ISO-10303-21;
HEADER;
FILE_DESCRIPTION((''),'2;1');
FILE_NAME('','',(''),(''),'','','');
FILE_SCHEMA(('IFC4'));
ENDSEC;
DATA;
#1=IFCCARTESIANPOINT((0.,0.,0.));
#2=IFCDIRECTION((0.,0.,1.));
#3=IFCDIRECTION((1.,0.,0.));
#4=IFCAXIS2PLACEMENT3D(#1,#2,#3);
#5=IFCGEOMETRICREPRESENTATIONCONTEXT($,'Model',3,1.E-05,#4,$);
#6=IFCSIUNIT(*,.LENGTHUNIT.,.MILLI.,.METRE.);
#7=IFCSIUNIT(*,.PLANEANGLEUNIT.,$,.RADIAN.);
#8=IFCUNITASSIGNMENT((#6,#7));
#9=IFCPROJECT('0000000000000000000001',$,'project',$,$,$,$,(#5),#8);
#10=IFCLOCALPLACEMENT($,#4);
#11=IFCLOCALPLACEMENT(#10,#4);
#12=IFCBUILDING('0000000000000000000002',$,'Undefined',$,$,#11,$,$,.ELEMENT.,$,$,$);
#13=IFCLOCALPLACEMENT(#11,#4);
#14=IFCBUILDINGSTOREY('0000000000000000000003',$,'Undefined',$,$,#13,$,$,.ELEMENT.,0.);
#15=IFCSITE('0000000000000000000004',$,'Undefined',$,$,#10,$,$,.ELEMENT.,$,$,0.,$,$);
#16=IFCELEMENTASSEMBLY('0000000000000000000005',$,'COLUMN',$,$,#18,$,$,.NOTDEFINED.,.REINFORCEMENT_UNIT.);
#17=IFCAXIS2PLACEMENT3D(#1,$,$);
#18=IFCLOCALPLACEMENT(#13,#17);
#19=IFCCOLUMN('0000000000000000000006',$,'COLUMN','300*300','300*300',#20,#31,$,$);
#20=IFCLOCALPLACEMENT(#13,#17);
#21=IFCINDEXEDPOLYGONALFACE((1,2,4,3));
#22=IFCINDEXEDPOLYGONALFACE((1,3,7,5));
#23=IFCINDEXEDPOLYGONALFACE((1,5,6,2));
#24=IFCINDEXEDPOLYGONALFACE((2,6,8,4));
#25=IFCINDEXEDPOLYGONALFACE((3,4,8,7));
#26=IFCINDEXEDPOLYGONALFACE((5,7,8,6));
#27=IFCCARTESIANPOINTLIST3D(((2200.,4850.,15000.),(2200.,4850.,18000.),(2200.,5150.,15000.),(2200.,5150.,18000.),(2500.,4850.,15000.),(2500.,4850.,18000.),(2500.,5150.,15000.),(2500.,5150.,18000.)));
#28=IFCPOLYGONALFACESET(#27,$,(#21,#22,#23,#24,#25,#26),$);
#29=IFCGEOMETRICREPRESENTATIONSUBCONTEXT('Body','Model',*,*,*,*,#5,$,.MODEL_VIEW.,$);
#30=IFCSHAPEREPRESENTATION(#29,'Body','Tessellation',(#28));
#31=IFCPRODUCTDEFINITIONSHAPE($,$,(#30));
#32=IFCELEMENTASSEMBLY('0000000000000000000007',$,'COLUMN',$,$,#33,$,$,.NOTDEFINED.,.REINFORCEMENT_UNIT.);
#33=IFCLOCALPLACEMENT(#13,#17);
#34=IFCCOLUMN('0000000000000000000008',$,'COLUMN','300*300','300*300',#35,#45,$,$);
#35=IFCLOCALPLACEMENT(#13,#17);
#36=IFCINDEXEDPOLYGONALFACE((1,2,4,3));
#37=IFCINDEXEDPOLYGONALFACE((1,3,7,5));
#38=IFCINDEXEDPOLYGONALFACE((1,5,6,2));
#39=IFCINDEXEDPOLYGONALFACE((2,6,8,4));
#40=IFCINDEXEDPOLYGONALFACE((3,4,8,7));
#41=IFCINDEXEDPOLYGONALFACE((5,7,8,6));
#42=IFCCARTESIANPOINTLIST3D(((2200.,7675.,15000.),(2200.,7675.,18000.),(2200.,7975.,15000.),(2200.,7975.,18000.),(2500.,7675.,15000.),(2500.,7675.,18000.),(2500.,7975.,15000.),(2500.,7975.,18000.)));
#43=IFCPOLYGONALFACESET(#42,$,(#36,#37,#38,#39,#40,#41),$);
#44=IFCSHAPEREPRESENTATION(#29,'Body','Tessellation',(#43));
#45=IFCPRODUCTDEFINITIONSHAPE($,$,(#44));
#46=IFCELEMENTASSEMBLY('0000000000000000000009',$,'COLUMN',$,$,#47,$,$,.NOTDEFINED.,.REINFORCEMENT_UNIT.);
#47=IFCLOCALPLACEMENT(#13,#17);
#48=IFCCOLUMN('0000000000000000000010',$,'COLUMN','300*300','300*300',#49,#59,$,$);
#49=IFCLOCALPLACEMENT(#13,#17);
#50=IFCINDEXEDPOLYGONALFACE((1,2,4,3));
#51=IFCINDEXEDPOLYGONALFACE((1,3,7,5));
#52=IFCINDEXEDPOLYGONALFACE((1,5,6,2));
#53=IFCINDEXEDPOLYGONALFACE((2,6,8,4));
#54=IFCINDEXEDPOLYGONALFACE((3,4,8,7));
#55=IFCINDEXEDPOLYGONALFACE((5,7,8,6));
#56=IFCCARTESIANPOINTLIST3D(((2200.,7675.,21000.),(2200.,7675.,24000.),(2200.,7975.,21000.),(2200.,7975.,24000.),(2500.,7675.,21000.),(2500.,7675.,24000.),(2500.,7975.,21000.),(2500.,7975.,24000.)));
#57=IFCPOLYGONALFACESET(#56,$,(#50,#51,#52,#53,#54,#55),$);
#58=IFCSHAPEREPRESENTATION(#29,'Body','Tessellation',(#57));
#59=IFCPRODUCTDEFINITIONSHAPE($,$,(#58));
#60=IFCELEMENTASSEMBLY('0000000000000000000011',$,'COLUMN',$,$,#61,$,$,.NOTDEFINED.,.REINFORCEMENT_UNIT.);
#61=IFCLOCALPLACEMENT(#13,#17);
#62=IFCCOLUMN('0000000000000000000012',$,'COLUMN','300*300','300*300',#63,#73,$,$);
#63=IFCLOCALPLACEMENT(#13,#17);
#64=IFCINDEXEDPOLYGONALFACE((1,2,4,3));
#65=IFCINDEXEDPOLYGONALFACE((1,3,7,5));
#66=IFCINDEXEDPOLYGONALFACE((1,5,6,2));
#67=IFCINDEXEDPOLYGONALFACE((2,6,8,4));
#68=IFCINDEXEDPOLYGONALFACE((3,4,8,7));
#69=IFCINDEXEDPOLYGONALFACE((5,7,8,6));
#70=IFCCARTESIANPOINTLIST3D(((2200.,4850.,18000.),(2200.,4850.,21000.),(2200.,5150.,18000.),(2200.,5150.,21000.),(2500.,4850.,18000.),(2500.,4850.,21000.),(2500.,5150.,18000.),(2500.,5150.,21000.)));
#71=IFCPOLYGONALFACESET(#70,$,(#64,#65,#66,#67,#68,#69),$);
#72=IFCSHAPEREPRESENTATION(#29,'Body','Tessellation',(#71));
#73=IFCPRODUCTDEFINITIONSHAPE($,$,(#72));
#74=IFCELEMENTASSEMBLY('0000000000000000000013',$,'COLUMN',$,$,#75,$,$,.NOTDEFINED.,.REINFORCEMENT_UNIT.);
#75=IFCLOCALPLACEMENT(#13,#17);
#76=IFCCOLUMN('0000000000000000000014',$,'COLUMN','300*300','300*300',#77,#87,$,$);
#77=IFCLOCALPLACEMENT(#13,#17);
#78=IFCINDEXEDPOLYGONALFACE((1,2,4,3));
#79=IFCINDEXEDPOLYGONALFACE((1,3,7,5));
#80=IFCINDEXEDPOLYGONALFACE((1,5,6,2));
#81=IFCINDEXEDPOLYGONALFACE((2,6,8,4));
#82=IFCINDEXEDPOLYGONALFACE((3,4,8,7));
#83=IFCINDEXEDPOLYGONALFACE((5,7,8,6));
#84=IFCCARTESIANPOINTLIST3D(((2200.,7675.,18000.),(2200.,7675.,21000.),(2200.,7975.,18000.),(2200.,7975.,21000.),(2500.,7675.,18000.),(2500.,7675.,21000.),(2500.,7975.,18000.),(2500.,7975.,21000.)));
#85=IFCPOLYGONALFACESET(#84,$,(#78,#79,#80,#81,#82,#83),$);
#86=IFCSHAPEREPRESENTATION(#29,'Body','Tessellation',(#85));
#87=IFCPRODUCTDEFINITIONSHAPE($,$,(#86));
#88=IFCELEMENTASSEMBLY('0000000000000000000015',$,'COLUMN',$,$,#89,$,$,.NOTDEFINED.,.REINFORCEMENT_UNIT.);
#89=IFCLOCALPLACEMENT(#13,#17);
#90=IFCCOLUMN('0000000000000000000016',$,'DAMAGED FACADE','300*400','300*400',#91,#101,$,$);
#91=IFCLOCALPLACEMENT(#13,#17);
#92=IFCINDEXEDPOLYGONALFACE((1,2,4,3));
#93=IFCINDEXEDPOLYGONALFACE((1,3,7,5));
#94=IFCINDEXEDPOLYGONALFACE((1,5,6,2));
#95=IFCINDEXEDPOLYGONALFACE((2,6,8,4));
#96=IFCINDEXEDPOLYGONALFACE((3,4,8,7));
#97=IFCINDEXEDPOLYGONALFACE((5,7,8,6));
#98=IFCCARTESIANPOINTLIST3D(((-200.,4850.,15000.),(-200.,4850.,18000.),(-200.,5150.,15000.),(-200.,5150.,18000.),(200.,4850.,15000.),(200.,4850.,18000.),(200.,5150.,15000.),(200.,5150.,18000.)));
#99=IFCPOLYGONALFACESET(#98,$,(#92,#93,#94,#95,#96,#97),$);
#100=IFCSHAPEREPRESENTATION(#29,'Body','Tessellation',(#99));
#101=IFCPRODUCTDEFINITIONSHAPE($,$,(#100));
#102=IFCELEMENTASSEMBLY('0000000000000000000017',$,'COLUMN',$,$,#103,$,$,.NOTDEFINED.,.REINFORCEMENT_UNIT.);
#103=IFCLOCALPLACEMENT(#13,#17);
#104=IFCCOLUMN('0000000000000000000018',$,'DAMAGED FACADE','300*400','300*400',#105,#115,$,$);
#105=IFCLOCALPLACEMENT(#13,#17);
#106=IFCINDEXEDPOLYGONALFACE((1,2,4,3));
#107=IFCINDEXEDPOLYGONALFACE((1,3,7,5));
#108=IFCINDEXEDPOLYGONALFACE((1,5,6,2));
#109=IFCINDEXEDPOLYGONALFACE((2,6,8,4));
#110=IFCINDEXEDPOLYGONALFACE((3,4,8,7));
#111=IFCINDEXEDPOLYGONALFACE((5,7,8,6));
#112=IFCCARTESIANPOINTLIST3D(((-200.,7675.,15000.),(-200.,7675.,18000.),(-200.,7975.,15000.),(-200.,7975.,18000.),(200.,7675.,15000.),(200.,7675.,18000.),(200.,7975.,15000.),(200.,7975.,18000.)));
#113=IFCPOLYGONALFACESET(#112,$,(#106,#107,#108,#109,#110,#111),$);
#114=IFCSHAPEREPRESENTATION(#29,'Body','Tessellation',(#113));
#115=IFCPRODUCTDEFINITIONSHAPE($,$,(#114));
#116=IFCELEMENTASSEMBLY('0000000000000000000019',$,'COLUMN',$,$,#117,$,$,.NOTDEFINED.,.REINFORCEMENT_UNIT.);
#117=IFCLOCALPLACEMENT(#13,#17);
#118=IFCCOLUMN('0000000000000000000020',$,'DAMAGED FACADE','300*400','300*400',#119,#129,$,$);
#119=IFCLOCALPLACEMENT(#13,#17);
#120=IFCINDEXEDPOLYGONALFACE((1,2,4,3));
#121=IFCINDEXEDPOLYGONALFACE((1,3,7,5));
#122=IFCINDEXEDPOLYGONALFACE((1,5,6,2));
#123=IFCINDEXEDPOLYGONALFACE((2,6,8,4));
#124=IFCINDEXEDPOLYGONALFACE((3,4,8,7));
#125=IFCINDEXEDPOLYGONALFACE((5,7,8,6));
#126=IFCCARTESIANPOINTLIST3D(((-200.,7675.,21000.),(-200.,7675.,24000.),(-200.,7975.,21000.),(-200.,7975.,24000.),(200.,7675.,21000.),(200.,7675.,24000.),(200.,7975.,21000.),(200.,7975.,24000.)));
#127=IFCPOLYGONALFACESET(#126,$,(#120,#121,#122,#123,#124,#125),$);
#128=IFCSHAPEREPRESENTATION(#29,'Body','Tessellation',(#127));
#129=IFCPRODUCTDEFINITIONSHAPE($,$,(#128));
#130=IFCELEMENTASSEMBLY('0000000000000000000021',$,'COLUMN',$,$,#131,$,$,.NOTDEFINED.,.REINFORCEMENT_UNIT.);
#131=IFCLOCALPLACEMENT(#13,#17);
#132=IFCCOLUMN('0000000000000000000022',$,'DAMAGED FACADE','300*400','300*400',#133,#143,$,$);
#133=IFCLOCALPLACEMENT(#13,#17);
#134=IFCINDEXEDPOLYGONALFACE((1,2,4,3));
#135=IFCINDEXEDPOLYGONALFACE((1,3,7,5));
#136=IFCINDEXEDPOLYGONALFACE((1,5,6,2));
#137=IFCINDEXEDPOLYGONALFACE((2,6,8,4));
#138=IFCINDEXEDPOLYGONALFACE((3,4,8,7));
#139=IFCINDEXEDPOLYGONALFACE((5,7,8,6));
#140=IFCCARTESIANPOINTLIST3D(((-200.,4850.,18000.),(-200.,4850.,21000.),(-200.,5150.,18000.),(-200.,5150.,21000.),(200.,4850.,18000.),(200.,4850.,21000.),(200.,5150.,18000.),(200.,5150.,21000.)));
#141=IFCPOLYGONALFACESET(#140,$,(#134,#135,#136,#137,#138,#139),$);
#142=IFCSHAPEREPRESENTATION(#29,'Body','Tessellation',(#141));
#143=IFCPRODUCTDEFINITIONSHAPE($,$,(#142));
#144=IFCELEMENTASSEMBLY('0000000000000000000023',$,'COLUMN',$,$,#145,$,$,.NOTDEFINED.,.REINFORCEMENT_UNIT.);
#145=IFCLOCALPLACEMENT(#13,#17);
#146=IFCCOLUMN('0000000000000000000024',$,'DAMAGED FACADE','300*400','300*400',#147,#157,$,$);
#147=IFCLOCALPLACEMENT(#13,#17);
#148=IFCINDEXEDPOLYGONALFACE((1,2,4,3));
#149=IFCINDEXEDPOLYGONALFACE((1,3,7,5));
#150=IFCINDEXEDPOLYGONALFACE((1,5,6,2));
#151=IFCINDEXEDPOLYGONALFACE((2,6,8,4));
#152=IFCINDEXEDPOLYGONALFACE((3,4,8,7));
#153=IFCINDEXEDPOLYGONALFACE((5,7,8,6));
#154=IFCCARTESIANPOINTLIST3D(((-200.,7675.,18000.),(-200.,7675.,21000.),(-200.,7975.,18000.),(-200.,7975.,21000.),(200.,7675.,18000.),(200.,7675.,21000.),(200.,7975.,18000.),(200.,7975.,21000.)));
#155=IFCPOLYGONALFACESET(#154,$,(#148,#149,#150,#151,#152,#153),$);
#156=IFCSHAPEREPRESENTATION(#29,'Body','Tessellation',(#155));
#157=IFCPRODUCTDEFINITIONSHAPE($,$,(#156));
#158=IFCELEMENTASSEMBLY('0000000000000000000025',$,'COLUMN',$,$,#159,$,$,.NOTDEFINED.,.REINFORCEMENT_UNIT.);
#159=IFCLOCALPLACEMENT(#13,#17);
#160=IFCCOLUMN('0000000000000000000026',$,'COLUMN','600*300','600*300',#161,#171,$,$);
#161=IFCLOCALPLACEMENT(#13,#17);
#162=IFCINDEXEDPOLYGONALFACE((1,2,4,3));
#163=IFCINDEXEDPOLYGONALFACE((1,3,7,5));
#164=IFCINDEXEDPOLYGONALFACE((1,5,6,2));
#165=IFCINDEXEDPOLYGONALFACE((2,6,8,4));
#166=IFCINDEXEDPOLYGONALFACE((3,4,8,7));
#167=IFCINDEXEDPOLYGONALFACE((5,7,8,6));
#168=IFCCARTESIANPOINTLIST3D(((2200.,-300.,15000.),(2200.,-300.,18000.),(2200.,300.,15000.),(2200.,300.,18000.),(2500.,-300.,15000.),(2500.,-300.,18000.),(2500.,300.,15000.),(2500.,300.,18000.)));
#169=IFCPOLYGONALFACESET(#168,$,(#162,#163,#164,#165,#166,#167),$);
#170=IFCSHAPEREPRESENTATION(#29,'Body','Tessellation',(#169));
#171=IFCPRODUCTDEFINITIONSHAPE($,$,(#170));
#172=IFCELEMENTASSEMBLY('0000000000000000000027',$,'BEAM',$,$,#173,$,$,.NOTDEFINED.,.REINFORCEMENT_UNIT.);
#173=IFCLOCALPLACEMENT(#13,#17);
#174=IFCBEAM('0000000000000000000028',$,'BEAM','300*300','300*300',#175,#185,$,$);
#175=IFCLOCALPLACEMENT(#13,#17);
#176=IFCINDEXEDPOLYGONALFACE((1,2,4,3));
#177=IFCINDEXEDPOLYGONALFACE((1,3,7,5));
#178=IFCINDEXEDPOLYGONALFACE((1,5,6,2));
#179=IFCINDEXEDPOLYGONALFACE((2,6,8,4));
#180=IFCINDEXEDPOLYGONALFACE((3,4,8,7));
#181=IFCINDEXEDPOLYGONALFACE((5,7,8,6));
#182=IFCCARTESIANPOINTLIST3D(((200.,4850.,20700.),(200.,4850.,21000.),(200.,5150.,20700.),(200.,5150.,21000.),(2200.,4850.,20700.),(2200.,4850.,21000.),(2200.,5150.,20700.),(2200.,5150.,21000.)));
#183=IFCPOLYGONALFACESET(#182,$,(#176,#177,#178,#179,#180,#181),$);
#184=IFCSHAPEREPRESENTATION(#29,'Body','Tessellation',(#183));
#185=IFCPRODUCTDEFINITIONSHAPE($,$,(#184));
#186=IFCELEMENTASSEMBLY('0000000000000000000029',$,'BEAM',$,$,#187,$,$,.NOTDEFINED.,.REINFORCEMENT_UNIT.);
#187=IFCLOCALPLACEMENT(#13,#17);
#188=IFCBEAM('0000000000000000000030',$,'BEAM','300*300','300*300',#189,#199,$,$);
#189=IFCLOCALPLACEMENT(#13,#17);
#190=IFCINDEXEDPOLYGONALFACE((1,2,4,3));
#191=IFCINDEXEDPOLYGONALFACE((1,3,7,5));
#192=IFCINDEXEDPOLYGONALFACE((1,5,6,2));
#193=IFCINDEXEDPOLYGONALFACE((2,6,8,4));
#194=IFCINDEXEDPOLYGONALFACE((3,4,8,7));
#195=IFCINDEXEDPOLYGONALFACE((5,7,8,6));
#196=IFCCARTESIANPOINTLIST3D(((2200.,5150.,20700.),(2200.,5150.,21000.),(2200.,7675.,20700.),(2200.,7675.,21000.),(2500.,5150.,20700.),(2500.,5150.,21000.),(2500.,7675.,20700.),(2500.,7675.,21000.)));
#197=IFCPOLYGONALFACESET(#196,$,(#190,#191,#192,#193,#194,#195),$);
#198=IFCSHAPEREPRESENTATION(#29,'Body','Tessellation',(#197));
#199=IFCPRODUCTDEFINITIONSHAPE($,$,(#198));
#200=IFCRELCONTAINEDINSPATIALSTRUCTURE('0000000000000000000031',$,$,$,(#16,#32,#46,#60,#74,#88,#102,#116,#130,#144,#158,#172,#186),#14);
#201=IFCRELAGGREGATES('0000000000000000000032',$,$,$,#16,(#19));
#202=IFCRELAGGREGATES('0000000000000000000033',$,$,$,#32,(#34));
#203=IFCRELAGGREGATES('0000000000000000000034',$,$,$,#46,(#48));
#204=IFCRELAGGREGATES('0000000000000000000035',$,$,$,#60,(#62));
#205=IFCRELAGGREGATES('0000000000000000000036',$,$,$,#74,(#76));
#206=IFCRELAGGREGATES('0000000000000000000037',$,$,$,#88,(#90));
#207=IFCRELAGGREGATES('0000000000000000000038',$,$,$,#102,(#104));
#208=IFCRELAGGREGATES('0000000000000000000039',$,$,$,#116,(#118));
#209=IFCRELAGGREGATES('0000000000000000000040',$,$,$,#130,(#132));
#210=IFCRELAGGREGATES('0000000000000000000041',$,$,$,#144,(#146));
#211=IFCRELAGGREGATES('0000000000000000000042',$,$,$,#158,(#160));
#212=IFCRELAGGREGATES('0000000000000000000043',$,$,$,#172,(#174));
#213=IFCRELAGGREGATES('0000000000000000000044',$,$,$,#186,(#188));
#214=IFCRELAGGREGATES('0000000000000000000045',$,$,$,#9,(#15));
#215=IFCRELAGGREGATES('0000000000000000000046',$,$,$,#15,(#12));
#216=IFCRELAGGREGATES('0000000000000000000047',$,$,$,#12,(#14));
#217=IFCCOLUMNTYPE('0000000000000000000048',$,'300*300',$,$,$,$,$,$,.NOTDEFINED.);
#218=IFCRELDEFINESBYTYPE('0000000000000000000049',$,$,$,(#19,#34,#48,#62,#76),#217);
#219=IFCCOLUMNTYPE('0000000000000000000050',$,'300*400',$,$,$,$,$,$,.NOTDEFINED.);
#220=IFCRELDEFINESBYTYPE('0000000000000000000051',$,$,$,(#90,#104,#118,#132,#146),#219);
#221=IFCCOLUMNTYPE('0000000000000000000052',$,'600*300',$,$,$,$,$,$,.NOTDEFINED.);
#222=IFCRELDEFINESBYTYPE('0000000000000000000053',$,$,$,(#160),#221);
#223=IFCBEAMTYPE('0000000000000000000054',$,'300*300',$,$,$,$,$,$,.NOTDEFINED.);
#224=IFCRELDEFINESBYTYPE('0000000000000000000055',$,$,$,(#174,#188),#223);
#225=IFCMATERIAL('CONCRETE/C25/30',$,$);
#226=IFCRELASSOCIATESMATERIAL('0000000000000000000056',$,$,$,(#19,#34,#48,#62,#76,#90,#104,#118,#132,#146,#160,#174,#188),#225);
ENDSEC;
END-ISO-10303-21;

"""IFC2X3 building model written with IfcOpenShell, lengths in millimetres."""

from ifc_helpers import new_model, si_unit, frame, origin_with_axes, origin_2d_with_axis, place, context, subcontext, project, spatial, rectangle, extrude, material, type_object, element, aggregate, save


model = new_model("IFC2X3")

# Units and contexts
model_context = context("Model", 3, precision=1e-05, world=origin_with_axes())
body_context = subcontext(model_context, "Body", "Model", "MODEL_VIEW")
ifc_project = project(units=[si_unit("LENGTHUNIT", "METRE", prefix="MILLI"), si_unit("PLANEANGLEUNIT", "RADIAN")], contexts=[model_context])

# Site, building, storey
site_placement = place(None, origin_with_axes())
site = spatial("IfcSite", under=ifc_project, at=site_placement, Name="Undefined", CompositionType="ELEMENT", RefElevation=0.0)
building_placement = place(site_placement, origin_with_axes())
building = spatial("IfcBuilding", under=site, at=building_placement, Name="Undefined", CompositionType="ELEMENT")
storey_placement = place(building_placement, origin_with_axes())
storey = spatial("IfcBuildingStorey", under=building, at=storey_placement, Name="Undefined", CompositionType="ELEMENT", Elevation=0.0)

# Element assemblies, columns
assembly_1_placement = place(storey_placement, origin_with_axes())
assembly_1 = element("IfcElementAssembly", 1, at=assembly_1_placement, inside=storey, Name="COLUMN", AssemblyPlace="NOTDEFINED", PredefinedType="REINFORCEMENT_UNIT")
ifc_material_1 = material(Name="CONCRETE/C25/30")
column_type_1 = type_object("IfcColumnType", Name="300*300", PredefinedType="NOTDEFINED")
column_1_placement = place(assembly_1_placement, frame((2350.0, 5000.0, 15000.0), z_axis=(0.0, 0.0, 1.0), x_axis=(1.0, 0.0, 0.0)))
column_1 = element("IfcColumn", 2, at=column_1_placement, type_object=column_type_1, material=ifc_material_1, Name="COLUMN", Description="300*300", ObjectType="300*300", context=body_context, shape_type="SweptSolid", body=[
    extrude(rectangle(XDim=300.0, YDim=300.0, at=origin_2d_with_axis()), frame((0.0, 0.0, 3000.0), z_axis=(0.0, 0.0, -1.0), x_axis=(-1.0, 0.0, 0.0)), (0.0, 0.0, 1.0), 3000.0),
])
aggregate(assembly_1, [column_1])
assembly_2_placement = place(storey_placement, origin_with_axes())
assembly_2 = element("IfcElementAssembly", 3, at=assembly_2_placement, inside=storey, Name="COLUMN", AssemblyPlace="NOTDEFINED", PredefinedType="REINFORCEMENT_UNIT")
column_2_placement = place(assembly_2_placement, frame((2350.0, 7825.0, 15000.0), z_axis=(0.0, 0.0, 1.0), x_axis=(1.0, 0.0, 0.0)))
column_2 = element("IfcColumn", 4, at=column_2_placement, type_object=column_type_1, material=ifc_material_1, Name="COLUMN", Description="300*300", ObjectType="300*300", context=body_context, shape_type="SweptSolid", body=[
    extrude(rectangle(XDim=300.0, YDim=300.0, at=origin_2d_with_axis()), frame((0.0, 0.0, 3000.0), z_axis=(0.0, 0.0, -1.0), x_axis=(-1.0, 0.0, 0.0)), (0.0, 0.0, 1.0), 3000.0),
])
aggregate(assembly_2, [column_2])
assembly_3_placement = place(storey_placement, origin_with_axes())
assembly_3 = element("IfcElementAssembly", 5, at=assembly_3_placement, inside=storey, Name="COLUMN", AssemblyPlace="NOTDEFINED", PredefinedType="REINFORCEMENT_UNIT")
column_3_placement = place(assembly_3_placement, frame((2350.0, 7825.0, 21000.0), z_axis=(0.0, 0.0, 1.0), x_axis=(1.0, 0.0, 0.0)))
column_3 = element("IfcColumn", 6, at=column_3_placement, type_object=column_type_1, material=ifc_material_1, Name="COLUMN", Description="300*300", ObjectType="300*300", context=body_context, shape_type="SweptSolid", body=[
    extrude(rectangle(XDim=300.0, YDim=300.0, at=origin_2d_with_axis()), frame((0.0, 0.0, 3000.0), z_axis=(0.0, 0.0, -1.0), x_axis=(-1.0, 0.0, 0.0)), (0.0, 0.0, 1.0), 3000.0),
])
aggregate(assembly_3, [column_3])
assembly_4_placement = place(storey_placement, origin_with_axes())
assembly_4 = element("IfcElementAssembly", 7, at=assembly_4_placement, inside=storey, Name="COLUMN", AssemblyPlace="NOTDEFINED", PredefinedType="REINFORCEMENT_UNIT")
column_4_placement = place(assembly_4_placement, frame((2350.0, 5000.0, 18000.0), z_axis=(0.0, 0.0, 1.0), x_axis=(1.0, 0.0, 0.0)))
column_4 = element("IfcColumn", 8, at=column_4_placement, type_object=column_type_1, material=ifc_material_1, Name="COLUMN", Description="300*300", ObjectType="300*300", context=body_context, shape_type="SweptSolid", body=[
    extrude(rectangle(XDim=300.0, YDim=300.0, at=origin_2d_with_axis()), frame((0.0, 0.0, 3000.0), z_axis=(0.0, 0.0, -1.0), x_axis=(-1.0, 0.0, 0.0)), (0.0, 0.0, 1.0), 3000.0),
])
aggregate(assembly_4, [column_4])
assembly_5_placement = place(storey_placement, origin_with_axes())
assembly_5 = element("IfcElementAssembly", 9, at=assembly_5_placement, inside=storey, Name="COLUMN", AssemblyPlace="NOTDEFINED", PredefinedType="REINFORCEMENT_UNIT")
column_5_placement = place(assembly_5_placement, frame((2350.0, 7825.0, 18000.0), z_axis=(0.0, 0.0, 1.0), x_axis=(1.0, 0.0, 0.0)))
column_5 = element("IfcColumn", 10, at=column_5_placement, type_object=column_type_1, material=ifc_material_1, Name="COLUMN", Description="300*300", ObjectType="300*300", context=body_context, shape_type="SweptSolid", body=[
    extrude(rectangle(XDim=300.0, YDim=300.0, at=origin_2d_with_axis()), frame((0.0, 0.0, 3000.0), z_axis=(0.0, 0.0, -1.0), x_axis=(-1.0, 0.0, 0.0)), (0.0, 0.0, 1.0), 3000.0),
])
aggregate(assembly_5, [column_5])
assembly_6_placement = place(storey_placement, origin_with_axes())
assembly_6 = element("IfcElementAssembly", 11, at=assembly_6_placement, inside=storey, Name="COLUMN", AssemblyPlace="NOTDEFINED", PredefinedType="REINFORCEMENT_UNIT")
column_type_2 = type_object("IfcColumnType", Name="300*400", PredefinedType="NOTDEFINED")
column_6_placement = place(assembly_6_placement, frame((0.0, 5000.0, 15000.0), z_axis=(0.0, 0.0, 1.0), x_axis=(1.0, 0.0, 0.0)))
column_6 = element("IfcColumn", 12, at=column_6_placement, type_object=column_type_2, material=ifc_material_1, Name="DAMAGED FACADE", Description="300*400", ObjectType="300*400", context=body_context, shape_type="SweptSolid", body=[
    extrude(rectangle(XDim=400.0, YDim=300.0, at=origin_2d_with_axis()), frame((0.0, 0.0, 3000.0), z_axis=(0.0, 0.0, -1.0), x_axis=(-1.0, 0.0, 0.0)), (0.0, 0.0, 1.0), 3000.0),
])
aggregate(assembly_6, [column_6])
assembly_7_placement = place(storey_placement, origin_with_axes())
assembly_7 = element("IfcElementAssembly", 13, at=assembly_7_placement, inside=storey, Name="COLUMN", AssemblyPlace="NOTDEFINED", PredefinedType="REINFORCEMENT_UNIT")
column_7_placement = place(assembly_7_placement, frame((0.0, 7825.0, 15000.0), z_axis=(0.0, 0.0, 1.0), x_axis=(1.0, 0.0, 0.0)))
column_7 = element("IfcColumn", 14, at=column_7_placement, type_object=column_type_2, material=ifc_material_1, Name="DAMAGED FACADE", Description="300*400", ObjectType="300*400", context=body_context, shape_type="SweptSolid", body=[
    extrude(rectangle(XDim=400.0, YDim=300.0, at=origin_2d_with_axis()), frame((0.0, 0.0, 3000.0), z_axis=(0.0, 0.0, -1.0), x_axis=(-1.0, 0.0, 0.0)), (0.0, 0.0, 1.0), 3000.0),
])
aggregate(assembly_7, [column_7])
assembly_8_placement = place(storey_placement, origin_with_axes())
assembly_8 = element("IfcElementAssembly", 15, at=assembly_8_placement, inside=storey, Name="COLUMN", AssemblyPlace="NOTDEFINED", PredefinedType="REINFORCEMENT_UNIT")
column_8_placement = place(assembly_8_placement, frame((0.0, 7825.0, 21000.0), z_axis=(0.0, 0.0, 1.0), x_axis=(1.0, 0.0, 0.0)))
column_8 = element("IfcColumn", 16, at=column_8_placement, type_object=column_type_2, material=ifc_material_1, Name="DAMAGED FACADE", Description="300*400", ObjectType="300*400", context=body_context, shape_type="SweptSolid", body=[
    extrude(rectangle(XDim=400.0, YDim=300.0, at=origin_2d_with_axis()), frame((0.0, 0.0, 3000.0), z_axis=(0.0, 0.0, -1.0), x_axis=(-1.0, 0.0, 0.0)), (0.0, 0.0, 1.0), 3000.0),
])
aggregate(assembly_8, [column_8])
assembly_9_placement = place(storey_placement, origin_with_axes())
assembly_9 = element("IfcElementAssembly", 17, at=assembly_9_placement, inside=storey, Name="COLUMN", AssemblyPlace="NOTDEFINED", PredefinedType="REINFORCEMENT_UNIT")
column_9_placement = place(assembly_9_placement, frame((0.0, 5000.0, 18000.0), z_axis=(0.0, 0.0, 1.0), x_axis=(1.0, 0.0, 0.0)))
column_9 = element("IfcColumn", 18, at=column_9_placement, type_object=column_type_2, material=ifc_material_1, Name="DAMAGED FACADE", Description="300*400", ObjectType="300*400", context=body_context, shape_type="SweptSolid", body=[
    extrude(rectangle(XDim=400.0, YDim=300.0, at=origin_2d_with_axis()), frame((0.0, 0.0, 3000.0), z_axis=(0.0, 0.0, -1.0), x_axis=(-1.0, 0.0, 0.0)), (0.0, 0.0, 1.0), 3000.0),
])
aggregate(assembly_9, [column_9])
assembly_10_placement = place(storey_placement, origin_with_axes())
assembly_10 = element("IfcElementAssembly", 19, at=assembly_10_placement, inside=storey, Name="COLUMN", AssemblyPlace="NOTDEFINED", PredefinedType="REINFORCEMENT_UNIT")
column_10_placement = place(assembly_10_placement, frame((0.0, 7825.0, 18000.0), z_axis=(0.0, 0.0, 1.0), x_axis=(1.0, 0.0, 0.0)))
column_10 = element("IfcColumn", 20, at=column_10_placement, type_object=column_type_2, material=ifc_material_1, Name="DAMAGED FACADE", Description="300*400", ObjectType="300*400", context=body_context, shape_type="SweptSolid", body=[
    extrude(rectangle(XDim=400.0, YDim=300.0, at=origin_2d_with_axis()), frame((0.0, 0.0, 3000.0), z_axis=(0.0, 0.0, -1.0), x_axis=(-1.0, 0.0, 0.0)), (0.0, 0.0, 1.0), 3000.0),
])
aggregate(assembly_10, [column_10])
assembly_11_placement = place(storey_placement, origin_with_axes())
assembly_11 = element("IfcElementAssembly", 21, at=assembly_11_placement, inside=storey, Name="COLUMN", AssemblyPlace="NOTDEFINED", PredefinedType="REINFORCEMENT_UNIT")
column_type_3 = type_object("IfcColumnType", Name="600*300", PredefinedType="NOTDEFINED")
column_11_placement = place(assembly_11_placement, frame((2350.0, 0.0, 15000.0), z_axis=(0.0, 0.0, 1.0), x_axis=(1.0, 0.0, 0.0)))
column_11 = element("IfcColumn", 22, at=column_11_placement, type_object=column_type_3, material=ifc_material_1, Name="COLUMN", Description="600*300", ObjectType="600*300", context=body_context, shape_type="SweptSolid", body=[
    extrude(rectangle(XDim=300.0, YDim=600.0, at=origin_2d_with_axis()), frame((0.0, 0.0, 3000.0), z_axis=(0.0, 0.0, -1.0), x_axis=(-1.0, 0.0, 0.0)), (0.0, 0.0, 1.0), 3000.0),
])
aggregate(assembly_11, [column_11])

# Element assemblies, beams
beam_type_1 = type_object("IfcBeamType", Name="300*300", PredefinedType="NOTDEFINED")
assembly_12_placement = place(storey_placement, origin_with_axes())
assembly_12 = element("IfcElementAssembly", 23, at=assembly_12_placement, inside=storey, Name="BEAM", AssemblyPlace="NOTDEFINED", PredefinedType="REINFORCEMENT_UNIT")
beam_1_placement = place(assembly_12_placement, frame((200.0, 5000.0, 20850.0), z_axis=(0.0, 0.0, 1.0), x_axis=(1.0, 0.0, 0.0)))
beam_1 = element("IfcBeam", 24, at=beam_1_placement, type_object=beam_type_1, material=ifc_material_1, Name="BEAM", Description="300*300", ObjectType="300*300", context=body_context, shape_type="SweptSolid", body=[
    extrude(rectangle(XDim=300.0, YDim=300.0, at=origin_2d_with_axis()), frame((2000.0, 0.0, 0.0), z_axis=(-1.0, 0.0, 0.0), x_axis=(0.0, -1.0, 0.0)), (0.0, 0.0, 1.0), 2000.0),
])
aggregate(assembly_12, [beam_1])
assembly_13_placement = place(storey_placement, origin_with_axes())
assembly_13 = element("IfcElementAssembly", 25, at=assembly_13_placement, inside=storey, Name="BEAM", AssemblyPlace="NOTDEFINED", PredefinedType="REINFORCEMENT_UNIT")
beam_2_placement = place(assembly_13_placement, frame((2350.0, 7675.0, 20850.0), z_axis=(0.0, 0.0, 1.0), x_axis=(0.0, -1.0, 0.0)))
beam_2 = element("IfcBeam", 26, at=beam_2_placement, type_object=beam_type_1, material=ifc_material_1, Name="BEAM", Description="300*300", ObjectType="300*300", context=body_context, shape_type="SweptSolid", body=[
    extrude(rectangle(XDim=300.0, YDim=300.0, at=origin_2d_with_axis()), frame((2525.0, 0.0, 0.0), z_axis=(-1.0, 0.0, 0.0), x_axis=(0.0, -1.0, 0.0)), (0.0, 0.0, 1.0), 2525.0),
])
aggregate(assembly_13, [beam_2])

save(model, "model.ifc")
